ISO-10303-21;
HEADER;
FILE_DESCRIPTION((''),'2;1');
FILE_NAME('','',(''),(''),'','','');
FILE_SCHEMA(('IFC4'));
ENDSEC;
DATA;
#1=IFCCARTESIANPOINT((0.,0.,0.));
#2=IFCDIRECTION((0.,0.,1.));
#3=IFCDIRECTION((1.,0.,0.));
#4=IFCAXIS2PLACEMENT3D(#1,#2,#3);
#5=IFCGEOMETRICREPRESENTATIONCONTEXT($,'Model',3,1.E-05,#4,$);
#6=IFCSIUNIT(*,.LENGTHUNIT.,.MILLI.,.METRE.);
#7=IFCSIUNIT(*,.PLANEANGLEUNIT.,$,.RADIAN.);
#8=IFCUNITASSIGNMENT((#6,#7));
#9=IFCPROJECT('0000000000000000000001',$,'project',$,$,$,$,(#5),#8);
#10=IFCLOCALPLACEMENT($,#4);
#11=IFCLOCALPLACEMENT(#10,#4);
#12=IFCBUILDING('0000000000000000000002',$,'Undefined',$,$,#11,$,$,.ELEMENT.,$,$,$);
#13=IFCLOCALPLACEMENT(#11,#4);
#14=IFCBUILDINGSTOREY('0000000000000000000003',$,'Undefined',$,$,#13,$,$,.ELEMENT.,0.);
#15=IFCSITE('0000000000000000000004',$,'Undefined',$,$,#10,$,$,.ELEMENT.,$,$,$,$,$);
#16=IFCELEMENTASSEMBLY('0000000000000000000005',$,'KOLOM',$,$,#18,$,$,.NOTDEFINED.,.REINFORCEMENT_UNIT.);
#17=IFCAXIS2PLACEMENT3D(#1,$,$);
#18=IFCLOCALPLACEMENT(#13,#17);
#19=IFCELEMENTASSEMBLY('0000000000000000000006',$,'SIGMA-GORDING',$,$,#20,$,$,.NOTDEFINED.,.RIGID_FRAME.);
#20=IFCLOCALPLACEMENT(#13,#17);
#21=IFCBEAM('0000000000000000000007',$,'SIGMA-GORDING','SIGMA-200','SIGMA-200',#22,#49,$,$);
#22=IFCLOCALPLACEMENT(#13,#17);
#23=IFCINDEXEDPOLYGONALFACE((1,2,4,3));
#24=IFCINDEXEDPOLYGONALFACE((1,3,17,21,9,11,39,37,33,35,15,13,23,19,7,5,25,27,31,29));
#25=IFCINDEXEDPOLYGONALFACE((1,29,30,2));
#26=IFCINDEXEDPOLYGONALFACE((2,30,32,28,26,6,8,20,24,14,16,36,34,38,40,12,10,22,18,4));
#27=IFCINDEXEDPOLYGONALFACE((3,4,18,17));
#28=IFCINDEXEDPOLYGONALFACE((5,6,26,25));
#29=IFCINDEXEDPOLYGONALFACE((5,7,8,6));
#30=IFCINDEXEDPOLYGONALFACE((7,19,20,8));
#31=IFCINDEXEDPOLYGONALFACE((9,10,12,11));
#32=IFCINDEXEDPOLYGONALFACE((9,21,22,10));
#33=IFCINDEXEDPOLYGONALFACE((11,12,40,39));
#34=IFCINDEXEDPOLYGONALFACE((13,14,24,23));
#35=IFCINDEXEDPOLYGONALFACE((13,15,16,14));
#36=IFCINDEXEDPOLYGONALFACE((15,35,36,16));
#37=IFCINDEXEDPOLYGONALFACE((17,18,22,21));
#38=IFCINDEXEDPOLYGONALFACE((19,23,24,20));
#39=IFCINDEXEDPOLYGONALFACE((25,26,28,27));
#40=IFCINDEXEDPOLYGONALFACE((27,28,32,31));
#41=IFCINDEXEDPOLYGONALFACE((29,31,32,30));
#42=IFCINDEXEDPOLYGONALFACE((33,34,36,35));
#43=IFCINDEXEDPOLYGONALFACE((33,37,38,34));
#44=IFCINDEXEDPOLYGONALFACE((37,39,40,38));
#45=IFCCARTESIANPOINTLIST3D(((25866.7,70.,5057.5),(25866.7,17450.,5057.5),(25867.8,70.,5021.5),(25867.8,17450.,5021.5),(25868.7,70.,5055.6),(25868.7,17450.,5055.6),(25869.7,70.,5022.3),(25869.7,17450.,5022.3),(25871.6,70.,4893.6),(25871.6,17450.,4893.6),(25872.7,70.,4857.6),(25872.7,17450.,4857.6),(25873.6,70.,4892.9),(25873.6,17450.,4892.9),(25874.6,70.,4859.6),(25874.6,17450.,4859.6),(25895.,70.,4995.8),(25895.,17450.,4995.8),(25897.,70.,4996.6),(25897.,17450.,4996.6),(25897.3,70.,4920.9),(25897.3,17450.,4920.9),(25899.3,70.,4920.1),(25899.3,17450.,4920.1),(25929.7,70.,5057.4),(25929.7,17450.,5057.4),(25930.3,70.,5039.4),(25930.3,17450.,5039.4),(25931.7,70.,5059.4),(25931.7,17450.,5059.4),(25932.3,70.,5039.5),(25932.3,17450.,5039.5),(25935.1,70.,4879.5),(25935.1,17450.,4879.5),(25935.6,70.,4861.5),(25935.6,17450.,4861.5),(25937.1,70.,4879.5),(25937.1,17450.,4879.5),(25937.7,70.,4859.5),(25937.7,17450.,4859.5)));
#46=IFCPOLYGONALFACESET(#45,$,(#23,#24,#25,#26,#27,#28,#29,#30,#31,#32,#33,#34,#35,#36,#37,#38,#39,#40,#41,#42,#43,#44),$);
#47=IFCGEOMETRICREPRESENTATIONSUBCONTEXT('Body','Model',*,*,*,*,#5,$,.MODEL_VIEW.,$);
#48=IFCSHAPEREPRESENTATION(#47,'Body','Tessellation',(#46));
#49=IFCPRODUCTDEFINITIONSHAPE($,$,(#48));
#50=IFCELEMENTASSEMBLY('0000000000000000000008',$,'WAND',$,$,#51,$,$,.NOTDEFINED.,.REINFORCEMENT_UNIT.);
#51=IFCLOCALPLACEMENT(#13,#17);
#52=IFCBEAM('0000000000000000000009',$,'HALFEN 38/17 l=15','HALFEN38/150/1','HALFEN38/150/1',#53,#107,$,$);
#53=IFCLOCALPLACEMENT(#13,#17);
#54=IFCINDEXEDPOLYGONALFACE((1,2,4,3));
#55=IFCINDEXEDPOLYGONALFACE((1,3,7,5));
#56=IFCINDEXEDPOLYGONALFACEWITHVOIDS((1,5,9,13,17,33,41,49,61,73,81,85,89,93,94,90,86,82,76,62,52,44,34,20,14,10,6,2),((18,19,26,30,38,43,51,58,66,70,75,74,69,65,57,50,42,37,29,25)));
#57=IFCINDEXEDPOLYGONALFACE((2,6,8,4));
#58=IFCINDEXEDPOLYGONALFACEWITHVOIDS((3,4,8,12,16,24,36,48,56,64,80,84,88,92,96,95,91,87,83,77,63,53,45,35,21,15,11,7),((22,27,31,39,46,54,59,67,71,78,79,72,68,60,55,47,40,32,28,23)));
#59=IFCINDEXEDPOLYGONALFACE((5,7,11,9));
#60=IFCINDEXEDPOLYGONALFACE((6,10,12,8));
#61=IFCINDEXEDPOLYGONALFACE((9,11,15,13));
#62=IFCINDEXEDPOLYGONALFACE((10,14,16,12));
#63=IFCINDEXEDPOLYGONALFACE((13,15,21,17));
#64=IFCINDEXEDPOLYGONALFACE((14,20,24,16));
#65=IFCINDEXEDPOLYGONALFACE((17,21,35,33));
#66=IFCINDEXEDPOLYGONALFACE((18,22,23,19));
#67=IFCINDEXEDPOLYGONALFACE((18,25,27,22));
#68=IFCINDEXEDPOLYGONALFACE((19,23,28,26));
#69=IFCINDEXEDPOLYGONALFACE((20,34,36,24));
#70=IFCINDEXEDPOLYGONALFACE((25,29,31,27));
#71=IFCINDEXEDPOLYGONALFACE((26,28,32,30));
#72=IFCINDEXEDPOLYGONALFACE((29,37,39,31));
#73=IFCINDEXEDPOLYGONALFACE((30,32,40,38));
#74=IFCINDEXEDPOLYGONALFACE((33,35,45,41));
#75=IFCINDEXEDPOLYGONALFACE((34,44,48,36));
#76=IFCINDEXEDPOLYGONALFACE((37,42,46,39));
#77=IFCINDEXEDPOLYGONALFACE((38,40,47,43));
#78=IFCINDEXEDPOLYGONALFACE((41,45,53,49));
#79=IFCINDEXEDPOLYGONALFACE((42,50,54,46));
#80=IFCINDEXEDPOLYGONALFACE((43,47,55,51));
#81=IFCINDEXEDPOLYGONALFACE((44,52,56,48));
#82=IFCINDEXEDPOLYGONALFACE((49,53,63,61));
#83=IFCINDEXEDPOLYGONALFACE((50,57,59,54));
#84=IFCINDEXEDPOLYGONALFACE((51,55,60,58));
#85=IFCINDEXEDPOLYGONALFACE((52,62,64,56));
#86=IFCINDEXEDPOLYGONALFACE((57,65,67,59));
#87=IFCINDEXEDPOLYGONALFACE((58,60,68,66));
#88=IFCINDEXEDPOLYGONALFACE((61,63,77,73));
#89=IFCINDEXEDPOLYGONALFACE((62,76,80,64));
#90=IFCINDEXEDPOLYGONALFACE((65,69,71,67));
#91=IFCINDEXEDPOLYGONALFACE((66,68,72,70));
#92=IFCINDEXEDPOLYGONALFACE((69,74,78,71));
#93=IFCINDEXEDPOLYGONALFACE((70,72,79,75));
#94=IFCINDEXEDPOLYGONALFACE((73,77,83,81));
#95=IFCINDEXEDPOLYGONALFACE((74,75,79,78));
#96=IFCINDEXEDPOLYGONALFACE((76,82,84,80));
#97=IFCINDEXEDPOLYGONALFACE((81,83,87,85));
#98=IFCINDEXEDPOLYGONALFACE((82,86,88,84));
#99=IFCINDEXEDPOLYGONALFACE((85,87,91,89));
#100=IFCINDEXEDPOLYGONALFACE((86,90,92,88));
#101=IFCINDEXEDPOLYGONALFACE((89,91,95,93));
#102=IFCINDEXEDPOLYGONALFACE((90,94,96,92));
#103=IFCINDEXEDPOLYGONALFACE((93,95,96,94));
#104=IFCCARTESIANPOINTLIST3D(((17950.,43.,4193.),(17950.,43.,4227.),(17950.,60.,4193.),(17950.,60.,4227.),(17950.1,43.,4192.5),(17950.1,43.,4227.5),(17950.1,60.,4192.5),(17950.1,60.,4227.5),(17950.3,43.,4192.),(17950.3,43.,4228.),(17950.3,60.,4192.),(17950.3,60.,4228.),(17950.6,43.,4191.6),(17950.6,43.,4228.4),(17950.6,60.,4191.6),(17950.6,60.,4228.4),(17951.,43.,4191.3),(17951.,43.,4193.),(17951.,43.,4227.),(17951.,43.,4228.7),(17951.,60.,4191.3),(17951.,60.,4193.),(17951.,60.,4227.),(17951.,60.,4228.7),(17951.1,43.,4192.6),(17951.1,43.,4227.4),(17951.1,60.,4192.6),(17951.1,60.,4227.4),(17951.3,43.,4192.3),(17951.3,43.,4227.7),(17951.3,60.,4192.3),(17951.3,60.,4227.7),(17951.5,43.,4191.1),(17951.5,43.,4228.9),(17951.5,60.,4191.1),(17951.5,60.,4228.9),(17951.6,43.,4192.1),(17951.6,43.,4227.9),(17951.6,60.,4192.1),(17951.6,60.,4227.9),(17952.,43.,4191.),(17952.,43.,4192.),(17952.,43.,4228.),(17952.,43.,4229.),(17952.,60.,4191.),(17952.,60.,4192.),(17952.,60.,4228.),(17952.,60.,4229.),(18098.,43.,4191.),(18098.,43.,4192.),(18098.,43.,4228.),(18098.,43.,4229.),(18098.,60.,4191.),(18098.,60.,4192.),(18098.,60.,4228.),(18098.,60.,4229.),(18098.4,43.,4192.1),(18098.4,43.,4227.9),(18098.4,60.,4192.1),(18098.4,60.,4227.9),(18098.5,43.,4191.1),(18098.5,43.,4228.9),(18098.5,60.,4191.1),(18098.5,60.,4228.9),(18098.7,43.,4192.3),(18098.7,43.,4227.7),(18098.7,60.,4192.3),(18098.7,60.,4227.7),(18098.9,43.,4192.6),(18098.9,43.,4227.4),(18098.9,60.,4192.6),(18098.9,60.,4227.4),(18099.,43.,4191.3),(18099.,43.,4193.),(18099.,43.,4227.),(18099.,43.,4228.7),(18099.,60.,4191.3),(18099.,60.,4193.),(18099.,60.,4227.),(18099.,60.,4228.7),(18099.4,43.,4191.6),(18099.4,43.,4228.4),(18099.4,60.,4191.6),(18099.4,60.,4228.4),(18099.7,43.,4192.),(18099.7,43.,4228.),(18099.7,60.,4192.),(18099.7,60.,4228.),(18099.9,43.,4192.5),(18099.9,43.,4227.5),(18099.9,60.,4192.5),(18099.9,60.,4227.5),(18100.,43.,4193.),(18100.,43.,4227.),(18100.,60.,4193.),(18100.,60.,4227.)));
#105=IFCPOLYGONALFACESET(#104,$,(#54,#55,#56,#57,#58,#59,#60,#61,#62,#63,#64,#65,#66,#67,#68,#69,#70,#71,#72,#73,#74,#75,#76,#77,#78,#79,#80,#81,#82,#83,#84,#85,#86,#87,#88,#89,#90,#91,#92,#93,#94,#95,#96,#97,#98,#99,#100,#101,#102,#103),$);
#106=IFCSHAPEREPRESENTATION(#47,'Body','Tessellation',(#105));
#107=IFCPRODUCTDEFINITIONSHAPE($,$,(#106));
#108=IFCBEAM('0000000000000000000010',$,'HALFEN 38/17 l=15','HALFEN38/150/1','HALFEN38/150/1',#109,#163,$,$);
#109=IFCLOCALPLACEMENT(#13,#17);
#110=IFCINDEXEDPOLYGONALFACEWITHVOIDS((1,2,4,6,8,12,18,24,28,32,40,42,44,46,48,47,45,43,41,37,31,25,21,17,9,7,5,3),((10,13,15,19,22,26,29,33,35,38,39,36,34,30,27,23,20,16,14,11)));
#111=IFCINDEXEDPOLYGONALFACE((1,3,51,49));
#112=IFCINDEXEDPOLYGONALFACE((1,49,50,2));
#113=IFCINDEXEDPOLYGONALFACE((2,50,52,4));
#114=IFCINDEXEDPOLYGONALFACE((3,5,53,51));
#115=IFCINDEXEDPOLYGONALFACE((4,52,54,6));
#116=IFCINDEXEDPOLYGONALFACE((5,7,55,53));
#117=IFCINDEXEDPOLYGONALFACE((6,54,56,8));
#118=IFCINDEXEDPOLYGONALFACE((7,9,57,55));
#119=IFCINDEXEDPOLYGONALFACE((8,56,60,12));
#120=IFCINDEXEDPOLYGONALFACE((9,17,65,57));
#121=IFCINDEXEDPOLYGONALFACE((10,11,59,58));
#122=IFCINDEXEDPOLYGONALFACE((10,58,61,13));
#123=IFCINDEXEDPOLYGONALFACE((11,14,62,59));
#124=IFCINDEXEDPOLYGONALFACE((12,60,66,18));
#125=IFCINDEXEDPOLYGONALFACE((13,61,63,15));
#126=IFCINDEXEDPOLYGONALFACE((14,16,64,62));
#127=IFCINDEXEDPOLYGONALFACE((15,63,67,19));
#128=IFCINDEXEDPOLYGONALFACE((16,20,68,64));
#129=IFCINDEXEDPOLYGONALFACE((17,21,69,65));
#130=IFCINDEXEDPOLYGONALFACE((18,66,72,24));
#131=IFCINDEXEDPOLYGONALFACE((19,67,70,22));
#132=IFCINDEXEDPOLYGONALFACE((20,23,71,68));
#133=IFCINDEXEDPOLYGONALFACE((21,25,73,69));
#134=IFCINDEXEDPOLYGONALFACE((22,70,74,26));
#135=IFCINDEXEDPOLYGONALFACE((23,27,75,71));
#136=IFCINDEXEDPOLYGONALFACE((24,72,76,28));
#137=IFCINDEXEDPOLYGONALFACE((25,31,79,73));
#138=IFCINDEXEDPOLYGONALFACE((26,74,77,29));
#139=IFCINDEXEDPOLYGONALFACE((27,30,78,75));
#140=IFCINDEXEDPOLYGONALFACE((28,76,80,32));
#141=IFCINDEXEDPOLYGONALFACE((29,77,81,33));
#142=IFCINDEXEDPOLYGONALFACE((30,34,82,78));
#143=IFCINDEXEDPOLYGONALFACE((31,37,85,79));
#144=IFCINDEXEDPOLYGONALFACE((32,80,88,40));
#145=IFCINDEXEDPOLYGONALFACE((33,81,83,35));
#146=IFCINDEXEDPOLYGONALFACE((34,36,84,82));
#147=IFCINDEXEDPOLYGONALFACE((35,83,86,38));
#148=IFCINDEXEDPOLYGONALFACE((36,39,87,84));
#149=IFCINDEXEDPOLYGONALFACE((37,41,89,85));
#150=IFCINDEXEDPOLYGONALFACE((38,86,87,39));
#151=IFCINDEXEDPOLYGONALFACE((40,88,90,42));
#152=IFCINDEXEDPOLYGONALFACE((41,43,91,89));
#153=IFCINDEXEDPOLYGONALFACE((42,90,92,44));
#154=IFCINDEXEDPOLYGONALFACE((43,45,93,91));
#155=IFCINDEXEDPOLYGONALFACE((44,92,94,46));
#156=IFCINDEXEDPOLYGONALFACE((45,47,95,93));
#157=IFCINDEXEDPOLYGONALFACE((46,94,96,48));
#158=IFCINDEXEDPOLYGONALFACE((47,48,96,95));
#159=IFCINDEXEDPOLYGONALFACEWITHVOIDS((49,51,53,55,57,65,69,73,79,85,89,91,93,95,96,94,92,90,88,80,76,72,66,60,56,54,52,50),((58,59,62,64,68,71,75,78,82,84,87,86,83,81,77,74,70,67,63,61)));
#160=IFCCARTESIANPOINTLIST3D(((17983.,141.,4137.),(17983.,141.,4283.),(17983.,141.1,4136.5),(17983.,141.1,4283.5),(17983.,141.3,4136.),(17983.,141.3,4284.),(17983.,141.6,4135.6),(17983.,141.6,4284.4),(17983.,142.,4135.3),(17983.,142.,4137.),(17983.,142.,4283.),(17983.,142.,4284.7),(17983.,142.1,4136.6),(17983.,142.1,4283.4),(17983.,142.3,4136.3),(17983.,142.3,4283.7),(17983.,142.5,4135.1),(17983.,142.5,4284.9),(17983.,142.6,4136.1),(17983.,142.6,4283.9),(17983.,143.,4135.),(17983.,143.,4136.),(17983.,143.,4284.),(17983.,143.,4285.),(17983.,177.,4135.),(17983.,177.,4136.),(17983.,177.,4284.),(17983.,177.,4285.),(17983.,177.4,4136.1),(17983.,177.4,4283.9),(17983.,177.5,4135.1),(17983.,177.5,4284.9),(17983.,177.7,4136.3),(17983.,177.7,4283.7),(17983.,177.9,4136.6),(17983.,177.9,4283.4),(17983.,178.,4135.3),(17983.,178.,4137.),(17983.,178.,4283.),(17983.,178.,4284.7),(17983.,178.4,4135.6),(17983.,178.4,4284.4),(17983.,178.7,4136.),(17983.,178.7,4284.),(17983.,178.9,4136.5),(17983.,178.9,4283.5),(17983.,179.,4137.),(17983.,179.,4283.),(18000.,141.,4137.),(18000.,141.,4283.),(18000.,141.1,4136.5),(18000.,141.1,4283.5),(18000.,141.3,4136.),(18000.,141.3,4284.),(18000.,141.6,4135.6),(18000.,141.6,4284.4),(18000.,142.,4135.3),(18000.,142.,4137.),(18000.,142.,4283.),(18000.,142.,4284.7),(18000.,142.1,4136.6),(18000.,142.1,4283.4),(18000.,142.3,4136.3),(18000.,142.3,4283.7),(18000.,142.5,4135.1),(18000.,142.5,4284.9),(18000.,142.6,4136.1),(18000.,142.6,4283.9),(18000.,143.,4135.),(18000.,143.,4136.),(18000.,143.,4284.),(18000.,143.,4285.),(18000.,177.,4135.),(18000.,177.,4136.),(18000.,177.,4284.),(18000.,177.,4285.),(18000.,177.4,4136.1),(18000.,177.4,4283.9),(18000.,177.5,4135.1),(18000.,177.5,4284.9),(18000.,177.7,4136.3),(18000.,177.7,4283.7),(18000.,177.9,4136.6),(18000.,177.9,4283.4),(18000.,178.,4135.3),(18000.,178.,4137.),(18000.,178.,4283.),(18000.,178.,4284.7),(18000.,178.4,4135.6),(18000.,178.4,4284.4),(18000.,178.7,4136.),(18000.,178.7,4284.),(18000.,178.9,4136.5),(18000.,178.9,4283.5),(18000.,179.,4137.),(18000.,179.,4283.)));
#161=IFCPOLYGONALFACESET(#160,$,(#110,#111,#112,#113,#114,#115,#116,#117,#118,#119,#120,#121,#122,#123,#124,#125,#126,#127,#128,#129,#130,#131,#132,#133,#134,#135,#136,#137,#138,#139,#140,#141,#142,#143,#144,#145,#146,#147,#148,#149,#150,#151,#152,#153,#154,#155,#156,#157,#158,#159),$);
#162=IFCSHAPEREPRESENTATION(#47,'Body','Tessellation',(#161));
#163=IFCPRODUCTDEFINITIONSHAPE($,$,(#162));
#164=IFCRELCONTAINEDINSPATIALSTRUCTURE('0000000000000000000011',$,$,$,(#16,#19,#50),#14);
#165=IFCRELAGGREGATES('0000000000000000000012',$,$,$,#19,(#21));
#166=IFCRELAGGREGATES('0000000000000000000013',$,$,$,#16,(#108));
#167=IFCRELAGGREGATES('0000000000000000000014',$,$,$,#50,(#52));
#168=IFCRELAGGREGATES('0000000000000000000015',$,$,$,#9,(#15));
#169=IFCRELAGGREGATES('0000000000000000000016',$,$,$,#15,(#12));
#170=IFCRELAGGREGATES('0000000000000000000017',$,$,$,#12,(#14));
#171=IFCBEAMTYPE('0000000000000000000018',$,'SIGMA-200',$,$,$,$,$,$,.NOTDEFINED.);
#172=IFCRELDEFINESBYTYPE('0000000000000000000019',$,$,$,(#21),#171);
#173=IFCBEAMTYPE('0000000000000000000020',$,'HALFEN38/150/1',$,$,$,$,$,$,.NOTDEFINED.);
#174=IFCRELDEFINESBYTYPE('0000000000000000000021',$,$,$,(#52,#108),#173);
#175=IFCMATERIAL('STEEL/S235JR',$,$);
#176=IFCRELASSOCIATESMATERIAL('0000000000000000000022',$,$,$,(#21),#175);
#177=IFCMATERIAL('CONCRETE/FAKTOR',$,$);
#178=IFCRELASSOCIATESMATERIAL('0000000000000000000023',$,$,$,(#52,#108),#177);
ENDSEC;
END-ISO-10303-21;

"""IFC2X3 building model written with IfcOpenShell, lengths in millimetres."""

from ifc_helpers import new_model, si_unit, frame, frame_2d, origin_with_axes, place, context, subcontext, project, spatial, polyline, hollow_rectangle, outline, extrude, material, type_object, element, aggregate, save


model = new_model("IFC2X3")

# Units and contexts
model_context = context("Model", 3, precision=1e-05, world=origin_with_axes())
body_context = subcontext(model_context, "Body", "Model", "MODEL_VIEW")
ifc_project = project(units=[si_unit("LENGTHUNIT", "METRE", prefix="MILLI"), si_unit("PLANEANGLEUNIT", "RADIAN")], contexts=[model_context])

# Site, building, storey
site_placement = place(None, origin_with_axes())
site = spatial("IfcSite", under=ifc_project, at=site_placement, Name="Undefined", CompositionType="ELEMENT")
building_placement = place(site_placement, origin_with_axes())
building = spatial("IfcBuilding", under=site, at=building_placement, Name="Undefined", CompositionType="ELEMENT")
storey_placement = place(building_placement, origin_with_axes())
storey = spatial("IfcBuildingStorey", under=building, at=storey_placement, Name="Undefined", CompositionType="ELEMENT", Elevation=0.0)

# Element assembly
assembly_1_placement = place(storey_placement, origin_with_axes())
assembly_1 = element("IfcElementAssembly", 1, at=assembly_1_placement, inside=storey, Name="KOLOM", AssemblyPlace="NOTDEFINED", PredefinedType="REINFORCEMENT_UNIT")
ifc_material_1 = material(Name="CONCRETE/FAKTOR")

# Element assemblies, beams
ifc_material_2 = material(Name="STEEL/S235JR")
beam_type_1 = type_object("IfcBeamType", Name="SIGMA-200", PredefinedType="NOTDEFINED")
assembly_2_placement = place(storey_placement, origin_with_axes())
assembly_2 = element("IfcElementAssembly", 2, at=assembly_2_placement, inside=storey, Name="SIGMA-GORDING", AssemblyPlace="NOTDEFINED", PredefinedType="RIGID_FRAME")
beam_1_placement = place(assembly_2_placement, frame((25902.2, 70.0, 4958.5), z_axis=(-0.029987, 0.0, 0.99955), x_axis=(0.0, 1.0, 0.0)))
beam_1 = element("IfcBeam", 3, at=beam_1_placement, type_object=beam_type_1, material=ifc_material_2, Name="SIGMA-GORDING", Description="SIGMA-200", ObjectType="SIGMA-200", context=body_context, shape_type="SweptSolid", body=[
    extrude(outline(polyline([(-6.0, 37.5), (-32.5, 64.0), (-32.5, 100.0), (32.5, 100.0), (32.5, 80.0), (30.5, 80.0), (30.5, 98.0), (-30.5, 98.0), (-30.5, 64.8), (-4.0, 38.3), (-4.0, -38.3), (-30.5, -64.8), (-30.5, -98.0), (30.5, -98.0), (30.5, -80.0), (32.5, -80.0), (32.5, -100.0), (-32.5, -100.0), (-32.5, -64.0), (-6.0, -37.5), (-6.0, 37.5)])), frame((17380.0, 0.0, 0.0), z_axis=(-1.0, 0.0, 0.0), x_axis=(0.0, -1.0, 0.0)), (0.0, 0.0, 1.0), 17380.0),
])
aggregate(assembly_2, [beam_1])
assembly_3_placement = place(storey_placement, origin_with_axes())
assembly_3 = element("IfcElementAssembly", 4, at=assembly_3_placement, inside=storey, Name="WAND", AssemblyPlace="NOTDEFINED", PredefinedType="REINFORCEMENT_UNIT")
beam_type_2 = type_object("IfcBeamType", Name="HALFEN38/150/1", PredefinedType="NOTDEFINED")
beam_2_placement = place(assembly_3_placement, frame((18025.0, 60.0, 4210.0), z_axis=(0.0, 0.0, -1.0), x_axis=(0.0, -1.0, 0.0)))
beam_2 = element("IfcBeam", 5, at=beam_2_placement, type_object=beam_type_2, material=ifc_material_1, Name="HALFEN 38/17 l=15", Description="HALFEN38/150/1", ObjectType="HALFEN38/150/1", context=body_context, shape_type="SweptSolid", body=[
    extrude(hollow_rectangle(XDim=150.0, YDim=38.0, WallThickness=1.0, InnerFilletRadius=1.0, OuterFilletRadius=2.0, at=frame_2d((0.0, 0.0), x_axis=(1.0, 0.0))), frame((17.0, 0.0, 0.0), z_axis=(-1.0, 0.0, 0.0), x_axis=(0.0, -1.0, 0.0)), (0.0, 0.0, 1.0), 17.0),
])

# Beam
beam_3_placement = place(assembly_1_placement, frame((18000.0, 160.0, 4210.0), z_axis=(0.0, 1.0, 0.0), x_axis=(-1.0, 0.0, 0.0)))
beam_3 = element("IfcBeam", 6, at=beam_3_placement, type_object=beam_type_2, material=ifc_material_1, Name="HALFEN 38/17 l=15", Description="HALFEN38/150/1", ObjectType="HALFEN38/150/1", context=body_context, shape_type="SweptSolid", body=[
    extrude(hollow_rectangle(XDim=150.0, YDim=38.0, WallThickness=1.0, InnerFilletRadius=1.0, OuterFilletRadius=2.0, at=frame_2d((0.0, 0.0), x_axis=(1.0, 0.0))), frame((17.0, 0.0, 0.0), z_axis=(-1.0, 0.0, 0.0), x_axis=(0.0, -1.0, 0.0)), (0.0, 0.0, 1.0), 17.0),
])
aggregate(assembly_1, [beam_3])
aggregate(assembly_3, [beam_2])

save(model, "model.ifc")
